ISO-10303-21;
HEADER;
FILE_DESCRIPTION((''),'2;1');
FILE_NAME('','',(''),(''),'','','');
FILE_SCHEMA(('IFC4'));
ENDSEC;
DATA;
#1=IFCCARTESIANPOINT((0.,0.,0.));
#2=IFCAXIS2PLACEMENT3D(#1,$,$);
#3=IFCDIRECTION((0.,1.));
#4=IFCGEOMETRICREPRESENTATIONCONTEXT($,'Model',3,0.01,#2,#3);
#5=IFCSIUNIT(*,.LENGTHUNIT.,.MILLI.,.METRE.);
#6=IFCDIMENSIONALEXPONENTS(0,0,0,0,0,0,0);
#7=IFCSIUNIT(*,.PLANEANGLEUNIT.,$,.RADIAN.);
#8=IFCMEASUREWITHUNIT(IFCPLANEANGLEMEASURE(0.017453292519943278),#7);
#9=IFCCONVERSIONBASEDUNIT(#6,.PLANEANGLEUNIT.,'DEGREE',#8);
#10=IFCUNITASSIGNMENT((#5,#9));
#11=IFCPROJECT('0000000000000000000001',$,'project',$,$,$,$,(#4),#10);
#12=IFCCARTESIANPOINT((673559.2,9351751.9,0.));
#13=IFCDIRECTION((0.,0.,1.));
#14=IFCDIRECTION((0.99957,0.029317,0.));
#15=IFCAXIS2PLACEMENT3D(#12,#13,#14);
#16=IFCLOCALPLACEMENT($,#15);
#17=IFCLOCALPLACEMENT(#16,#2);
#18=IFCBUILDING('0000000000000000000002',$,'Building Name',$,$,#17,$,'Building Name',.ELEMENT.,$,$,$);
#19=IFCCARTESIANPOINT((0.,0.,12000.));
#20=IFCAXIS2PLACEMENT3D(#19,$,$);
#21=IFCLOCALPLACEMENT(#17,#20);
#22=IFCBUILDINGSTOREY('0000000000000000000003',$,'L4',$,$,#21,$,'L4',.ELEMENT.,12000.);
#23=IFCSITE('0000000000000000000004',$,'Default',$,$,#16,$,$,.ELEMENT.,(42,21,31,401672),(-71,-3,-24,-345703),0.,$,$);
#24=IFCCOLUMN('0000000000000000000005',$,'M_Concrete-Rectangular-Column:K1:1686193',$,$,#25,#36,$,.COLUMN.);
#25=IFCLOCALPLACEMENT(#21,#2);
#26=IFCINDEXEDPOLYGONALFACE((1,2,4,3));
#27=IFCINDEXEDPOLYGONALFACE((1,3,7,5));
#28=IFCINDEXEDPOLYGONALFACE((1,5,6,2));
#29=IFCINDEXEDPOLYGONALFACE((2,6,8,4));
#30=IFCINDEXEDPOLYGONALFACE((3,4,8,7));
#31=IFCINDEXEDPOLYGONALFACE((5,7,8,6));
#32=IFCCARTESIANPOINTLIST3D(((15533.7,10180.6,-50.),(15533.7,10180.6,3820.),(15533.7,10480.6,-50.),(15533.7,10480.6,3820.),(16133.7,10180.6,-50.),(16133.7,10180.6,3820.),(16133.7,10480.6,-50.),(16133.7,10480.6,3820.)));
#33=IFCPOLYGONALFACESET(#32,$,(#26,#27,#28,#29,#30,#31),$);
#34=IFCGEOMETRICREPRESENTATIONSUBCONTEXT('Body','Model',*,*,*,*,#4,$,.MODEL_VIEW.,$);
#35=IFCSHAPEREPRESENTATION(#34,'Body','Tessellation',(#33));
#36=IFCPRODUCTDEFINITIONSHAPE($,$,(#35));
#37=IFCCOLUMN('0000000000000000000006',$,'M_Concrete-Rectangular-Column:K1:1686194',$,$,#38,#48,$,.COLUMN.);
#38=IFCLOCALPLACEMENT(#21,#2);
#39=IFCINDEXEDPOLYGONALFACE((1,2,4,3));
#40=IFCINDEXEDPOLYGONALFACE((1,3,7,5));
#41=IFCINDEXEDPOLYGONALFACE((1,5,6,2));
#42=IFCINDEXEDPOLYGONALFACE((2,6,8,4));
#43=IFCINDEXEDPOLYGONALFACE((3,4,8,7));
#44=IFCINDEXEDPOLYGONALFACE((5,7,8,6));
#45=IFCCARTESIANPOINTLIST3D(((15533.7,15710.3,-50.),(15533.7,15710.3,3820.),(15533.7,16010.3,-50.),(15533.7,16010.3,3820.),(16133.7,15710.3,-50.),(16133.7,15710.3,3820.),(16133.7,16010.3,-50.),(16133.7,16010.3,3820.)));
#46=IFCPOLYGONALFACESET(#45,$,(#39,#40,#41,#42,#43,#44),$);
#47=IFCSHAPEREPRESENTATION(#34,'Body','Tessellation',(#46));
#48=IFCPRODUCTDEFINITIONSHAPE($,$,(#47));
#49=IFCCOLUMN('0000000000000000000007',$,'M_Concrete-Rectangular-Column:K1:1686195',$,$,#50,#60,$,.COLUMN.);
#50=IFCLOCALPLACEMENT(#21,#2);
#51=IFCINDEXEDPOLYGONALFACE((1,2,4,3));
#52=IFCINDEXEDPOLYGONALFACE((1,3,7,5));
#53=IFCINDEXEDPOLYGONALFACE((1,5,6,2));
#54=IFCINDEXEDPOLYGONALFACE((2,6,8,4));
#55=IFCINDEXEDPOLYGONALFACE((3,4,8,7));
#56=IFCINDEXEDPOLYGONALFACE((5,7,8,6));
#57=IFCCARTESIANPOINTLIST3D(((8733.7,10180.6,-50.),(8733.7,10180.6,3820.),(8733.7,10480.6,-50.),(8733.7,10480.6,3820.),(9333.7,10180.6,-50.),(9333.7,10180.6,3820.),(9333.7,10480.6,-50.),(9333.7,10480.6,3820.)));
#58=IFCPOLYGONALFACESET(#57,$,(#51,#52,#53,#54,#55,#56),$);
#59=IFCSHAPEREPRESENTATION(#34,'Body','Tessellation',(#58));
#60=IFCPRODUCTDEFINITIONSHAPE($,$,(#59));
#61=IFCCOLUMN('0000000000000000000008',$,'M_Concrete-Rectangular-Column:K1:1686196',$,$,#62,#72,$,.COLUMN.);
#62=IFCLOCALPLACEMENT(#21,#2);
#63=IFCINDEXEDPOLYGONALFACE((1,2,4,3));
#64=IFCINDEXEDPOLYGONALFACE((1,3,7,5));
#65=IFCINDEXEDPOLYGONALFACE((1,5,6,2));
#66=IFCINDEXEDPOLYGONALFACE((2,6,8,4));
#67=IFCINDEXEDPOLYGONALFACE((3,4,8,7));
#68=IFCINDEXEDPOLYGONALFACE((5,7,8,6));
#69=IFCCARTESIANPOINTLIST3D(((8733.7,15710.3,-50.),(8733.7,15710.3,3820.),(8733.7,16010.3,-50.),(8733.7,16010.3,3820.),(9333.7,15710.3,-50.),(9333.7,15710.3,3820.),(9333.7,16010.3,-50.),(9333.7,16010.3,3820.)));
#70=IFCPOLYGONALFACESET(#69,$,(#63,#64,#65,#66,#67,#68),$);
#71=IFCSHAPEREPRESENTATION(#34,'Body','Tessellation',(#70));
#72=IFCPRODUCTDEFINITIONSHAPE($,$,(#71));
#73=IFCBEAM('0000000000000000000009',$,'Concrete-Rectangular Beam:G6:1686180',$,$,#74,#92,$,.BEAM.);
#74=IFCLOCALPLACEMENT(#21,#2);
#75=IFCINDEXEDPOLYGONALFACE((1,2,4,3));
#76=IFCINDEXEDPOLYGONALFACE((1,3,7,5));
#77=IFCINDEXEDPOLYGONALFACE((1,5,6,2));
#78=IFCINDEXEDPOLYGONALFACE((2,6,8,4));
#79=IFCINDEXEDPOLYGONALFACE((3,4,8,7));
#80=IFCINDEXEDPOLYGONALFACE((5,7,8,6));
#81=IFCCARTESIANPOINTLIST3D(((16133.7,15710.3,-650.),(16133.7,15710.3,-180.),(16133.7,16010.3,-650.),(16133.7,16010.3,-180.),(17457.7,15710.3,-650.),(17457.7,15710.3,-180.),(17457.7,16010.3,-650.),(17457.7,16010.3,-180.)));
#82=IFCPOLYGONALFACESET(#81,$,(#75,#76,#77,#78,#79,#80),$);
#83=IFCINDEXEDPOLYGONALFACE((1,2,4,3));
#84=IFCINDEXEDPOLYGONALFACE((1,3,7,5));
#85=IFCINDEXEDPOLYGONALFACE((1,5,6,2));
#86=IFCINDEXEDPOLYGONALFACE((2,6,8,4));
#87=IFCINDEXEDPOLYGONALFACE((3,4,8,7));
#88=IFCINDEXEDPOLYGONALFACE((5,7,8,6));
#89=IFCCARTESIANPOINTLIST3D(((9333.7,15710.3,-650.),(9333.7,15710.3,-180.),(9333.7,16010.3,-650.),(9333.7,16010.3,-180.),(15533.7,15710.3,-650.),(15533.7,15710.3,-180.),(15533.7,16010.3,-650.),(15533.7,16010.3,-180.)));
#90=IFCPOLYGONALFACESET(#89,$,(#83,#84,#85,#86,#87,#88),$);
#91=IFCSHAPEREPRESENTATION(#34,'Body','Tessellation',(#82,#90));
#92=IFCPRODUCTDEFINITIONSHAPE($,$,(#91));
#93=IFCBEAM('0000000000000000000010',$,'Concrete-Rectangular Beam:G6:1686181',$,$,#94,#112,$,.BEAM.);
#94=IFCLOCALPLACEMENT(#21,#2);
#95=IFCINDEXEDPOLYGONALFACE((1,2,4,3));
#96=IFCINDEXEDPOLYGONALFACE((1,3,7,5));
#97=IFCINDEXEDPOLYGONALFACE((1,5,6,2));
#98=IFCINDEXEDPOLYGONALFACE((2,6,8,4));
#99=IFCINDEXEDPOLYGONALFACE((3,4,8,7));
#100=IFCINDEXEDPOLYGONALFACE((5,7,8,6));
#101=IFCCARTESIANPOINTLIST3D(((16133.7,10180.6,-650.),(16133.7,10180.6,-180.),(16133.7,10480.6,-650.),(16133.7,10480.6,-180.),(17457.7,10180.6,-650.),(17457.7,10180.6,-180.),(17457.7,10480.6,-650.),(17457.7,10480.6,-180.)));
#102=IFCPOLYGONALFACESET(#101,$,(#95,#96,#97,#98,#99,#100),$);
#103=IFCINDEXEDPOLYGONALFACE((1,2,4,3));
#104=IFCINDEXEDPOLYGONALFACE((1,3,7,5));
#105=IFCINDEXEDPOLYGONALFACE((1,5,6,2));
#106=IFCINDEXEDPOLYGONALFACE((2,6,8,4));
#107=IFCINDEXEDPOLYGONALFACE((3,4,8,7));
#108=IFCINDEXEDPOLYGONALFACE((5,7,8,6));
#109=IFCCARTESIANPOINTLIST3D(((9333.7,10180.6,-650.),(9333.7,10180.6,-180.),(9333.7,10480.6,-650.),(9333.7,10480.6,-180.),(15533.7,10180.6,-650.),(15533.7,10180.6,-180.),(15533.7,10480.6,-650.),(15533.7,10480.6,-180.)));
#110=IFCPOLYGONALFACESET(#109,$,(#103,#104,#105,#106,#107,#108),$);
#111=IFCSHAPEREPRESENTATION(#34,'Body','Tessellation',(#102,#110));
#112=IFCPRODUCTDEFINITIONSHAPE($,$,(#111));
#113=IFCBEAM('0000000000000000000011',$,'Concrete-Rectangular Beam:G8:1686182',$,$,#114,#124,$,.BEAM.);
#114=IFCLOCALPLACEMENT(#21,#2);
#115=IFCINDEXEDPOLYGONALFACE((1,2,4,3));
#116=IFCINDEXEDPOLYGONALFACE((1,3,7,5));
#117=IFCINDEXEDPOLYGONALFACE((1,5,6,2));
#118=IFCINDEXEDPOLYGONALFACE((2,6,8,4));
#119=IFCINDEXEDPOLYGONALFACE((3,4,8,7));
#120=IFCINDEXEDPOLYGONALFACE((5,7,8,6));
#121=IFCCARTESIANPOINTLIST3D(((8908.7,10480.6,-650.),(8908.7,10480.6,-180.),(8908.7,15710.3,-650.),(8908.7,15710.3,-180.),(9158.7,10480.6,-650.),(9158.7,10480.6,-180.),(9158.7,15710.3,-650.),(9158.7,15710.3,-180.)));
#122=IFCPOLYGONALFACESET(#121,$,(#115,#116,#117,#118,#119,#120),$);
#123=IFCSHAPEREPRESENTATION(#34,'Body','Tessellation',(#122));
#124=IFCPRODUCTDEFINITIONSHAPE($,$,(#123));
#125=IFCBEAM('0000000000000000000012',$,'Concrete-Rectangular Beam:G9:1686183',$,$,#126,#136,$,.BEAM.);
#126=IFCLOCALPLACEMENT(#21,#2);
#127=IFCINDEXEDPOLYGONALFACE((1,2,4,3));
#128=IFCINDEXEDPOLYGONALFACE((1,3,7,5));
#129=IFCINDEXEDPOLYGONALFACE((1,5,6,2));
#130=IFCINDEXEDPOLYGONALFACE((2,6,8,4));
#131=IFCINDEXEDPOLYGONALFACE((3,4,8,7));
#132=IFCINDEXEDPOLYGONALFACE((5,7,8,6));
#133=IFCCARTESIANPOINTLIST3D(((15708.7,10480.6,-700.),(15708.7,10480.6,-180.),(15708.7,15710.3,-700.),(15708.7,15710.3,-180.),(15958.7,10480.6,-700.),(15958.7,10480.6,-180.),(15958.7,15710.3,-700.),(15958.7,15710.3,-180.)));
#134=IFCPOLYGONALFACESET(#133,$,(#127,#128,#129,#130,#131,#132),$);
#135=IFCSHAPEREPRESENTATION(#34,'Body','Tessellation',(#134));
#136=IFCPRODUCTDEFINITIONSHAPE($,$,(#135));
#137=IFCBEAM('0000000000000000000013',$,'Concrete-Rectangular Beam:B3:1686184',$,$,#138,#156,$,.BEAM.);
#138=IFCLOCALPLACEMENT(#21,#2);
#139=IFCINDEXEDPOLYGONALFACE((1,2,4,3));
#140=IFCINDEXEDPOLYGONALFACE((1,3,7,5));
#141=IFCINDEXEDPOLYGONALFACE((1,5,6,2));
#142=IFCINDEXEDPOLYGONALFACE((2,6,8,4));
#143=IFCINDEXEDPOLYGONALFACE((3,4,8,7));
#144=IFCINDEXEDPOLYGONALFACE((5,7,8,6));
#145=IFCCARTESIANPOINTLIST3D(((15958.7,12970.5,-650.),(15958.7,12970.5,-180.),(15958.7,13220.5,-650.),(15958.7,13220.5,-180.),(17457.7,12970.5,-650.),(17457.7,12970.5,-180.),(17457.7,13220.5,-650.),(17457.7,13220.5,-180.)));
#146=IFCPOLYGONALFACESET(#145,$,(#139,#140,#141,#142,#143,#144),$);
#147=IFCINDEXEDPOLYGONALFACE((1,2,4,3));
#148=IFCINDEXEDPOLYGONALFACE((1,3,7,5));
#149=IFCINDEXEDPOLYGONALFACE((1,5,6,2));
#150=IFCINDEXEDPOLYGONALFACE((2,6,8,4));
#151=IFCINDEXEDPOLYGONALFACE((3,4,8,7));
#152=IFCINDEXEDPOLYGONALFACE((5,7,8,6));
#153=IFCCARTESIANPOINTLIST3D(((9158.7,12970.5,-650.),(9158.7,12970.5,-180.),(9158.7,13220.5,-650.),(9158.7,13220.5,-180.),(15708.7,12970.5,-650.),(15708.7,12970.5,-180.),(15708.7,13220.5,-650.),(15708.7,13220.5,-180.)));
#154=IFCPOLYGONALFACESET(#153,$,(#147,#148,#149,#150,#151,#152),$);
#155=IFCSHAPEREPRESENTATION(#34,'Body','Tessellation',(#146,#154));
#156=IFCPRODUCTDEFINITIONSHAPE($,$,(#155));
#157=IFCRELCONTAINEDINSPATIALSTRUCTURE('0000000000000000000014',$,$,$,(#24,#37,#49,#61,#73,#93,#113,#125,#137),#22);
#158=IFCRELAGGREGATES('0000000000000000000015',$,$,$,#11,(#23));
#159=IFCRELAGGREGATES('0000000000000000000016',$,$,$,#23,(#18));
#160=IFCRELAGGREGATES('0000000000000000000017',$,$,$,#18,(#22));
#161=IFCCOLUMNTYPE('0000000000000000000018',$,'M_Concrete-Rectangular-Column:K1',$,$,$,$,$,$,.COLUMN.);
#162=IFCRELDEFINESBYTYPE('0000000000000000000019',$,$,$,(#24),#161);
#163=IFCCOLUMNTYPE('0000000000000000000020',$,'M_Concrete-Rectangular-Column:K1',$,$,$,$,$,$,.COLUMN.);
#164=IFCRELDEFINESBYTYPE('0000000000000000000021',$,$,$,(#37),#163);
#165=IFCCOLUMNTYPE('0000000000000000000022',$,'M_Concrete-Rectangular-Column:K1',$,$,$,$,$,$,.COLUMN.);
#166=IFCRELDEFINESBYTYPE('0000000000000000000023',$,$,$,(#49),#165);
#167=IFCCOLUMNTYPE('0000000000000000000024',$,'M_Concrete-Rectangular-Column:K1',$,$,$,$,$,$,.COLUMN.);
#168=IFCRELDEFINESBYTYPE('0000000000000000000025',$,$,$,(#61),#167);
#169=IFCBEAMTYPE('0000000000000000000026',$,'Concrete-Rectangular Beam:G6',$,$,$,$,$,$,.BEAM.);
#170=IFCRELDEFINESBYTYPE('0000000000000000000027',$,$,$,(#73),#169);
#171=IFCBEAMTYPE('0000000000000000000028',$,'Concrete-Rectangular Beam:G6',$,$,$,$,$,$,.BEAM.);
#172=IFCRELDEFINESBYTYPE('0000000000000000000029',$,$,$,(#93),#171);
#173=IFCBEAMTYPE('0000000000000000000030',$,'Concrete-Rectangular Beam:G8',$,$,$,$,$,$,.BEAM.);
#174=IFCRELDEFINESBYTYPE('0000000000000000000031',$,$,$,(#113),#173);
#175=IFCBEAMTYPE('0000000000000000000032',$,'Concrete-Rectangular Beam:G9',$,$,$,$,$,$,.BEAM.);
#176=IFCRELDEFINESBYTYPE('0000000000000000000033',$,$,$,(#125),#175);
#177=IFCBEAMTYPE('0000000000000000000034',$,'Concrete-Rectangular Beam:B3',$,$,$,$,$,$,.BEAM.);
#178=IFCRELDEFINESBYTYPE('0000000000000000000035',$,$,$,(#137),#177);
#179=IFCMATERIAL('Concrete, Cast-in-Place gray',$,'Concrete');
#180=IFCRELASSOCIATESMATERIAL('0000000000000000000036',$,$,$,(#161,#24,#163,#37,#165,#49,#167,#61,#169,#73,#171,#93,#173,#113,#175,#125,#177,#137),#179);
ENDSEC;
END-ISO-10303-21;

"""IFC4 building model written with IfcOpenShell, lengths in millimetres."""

from ifc_helpers import new_model, entity, si_unit, converted_unit, direction, frame, origin, place, context, subcontext, project, spatial, indexed_curve, outline, extrude, source, transform, mapped, material, type_object, type_shapes, element, save


model = new_model("IFC4")

# Units and contexts
model_context = context("Model", 3, precision=0.01, world=origin(), true_north=direction((0.0, 1.0)))
body_context = subcontext(model_context, "Body", "Model", "MODEL_VIEW")
ifc_project = project(units=[si_unit("LENGTHUNIT", "METRE", prefix="MILLI"), converted_unit("PLANEANGLEUNIT", "DEGREE", entity("IfcPlaneAngleMeasure", 0.017453292519943278), si_unit("PLANEANGLEUNIT", "RADIAN"), dimensions=[0, 0, 0, 0, 0, 0, 0])], contexts=[model_context])

# Site, building, storey
site_placement = place(None, frame((673559.2, 9351751.9, 0.0), z_axis=(0.0, 0.0, 1.0), x_axis=(0.99957, 0.029317, 0.0)))
site = spatial("IfcSite", under=ifc_project, at=site_placement, Name="Default", CompositionType="ELEMENT", RefLatitude=(42, 21, 31, 401672), RefLongitude=(-71, -3, -24, -345703), RefElevation=0.0)
building_placement = place(site_placement, origin())
building = spatial("IfcBuilding", under=site, at=building_placement, Name="Building Name", LongName="Building Name", CompositionType="ELEMENT")
storey_placement = place(building_placement, frame((0.0, 0.0, 12000.0)))
storey = spatial("IfcBuildingStorey", under=building, at=storey_placement, Name="L4", LongName="L4", CompositionType="ELEMENT", Elevation=12000.0)

# Columns
ifc_material = material(Name="Concrete, Cast-in-Place gray", Category="Concrete")
column_type_1 = type_object("IfcColumnType", Name="M_Concrete-Rectangular-Column:K1", PredefinedType="COLUMN", material=ifc_material)
shared_shape_1 = source(origin(), body_context, "Body", "SweptSolid", [
    extrude(outline(indexed_curve([(-150.0, -300.0), (150.0, -300.0), (150.0, 300.0), (-150.0, 300.0), (-150.0, -300.0)], self_intersect=False)), frame((15833.7, 10330.6, 11950.0), z_axis=(0.0, 0.0, 1.0), x_axis=(0.0, -1.0, 0.0)), (0.0, 0.0, 1.0), 3870.0),
])
type_shapes(column_type_1, [shared_shape_1])
column_1_placement = place(storey_placement, frame((0.0, 0.0, -12000.0)))
element("IfcColumn", 1, at=column_1_placement, inside=storey, type_object=column_type_1, material=ifc_material, Name="M_Concrete-Rectangular-Column:K1:1686193", PredefinedType="COLUMN", context=body_context, shape_type="MappedRepresentation", body=[
    mapped(shared_shape_1, transform((0.0, 0.0, 0.0), scale=1.0)),
])
column_type_2 = type_object("IfcColumnType", Name="M_Concrete-Rectangular-Column:K1", PredefinedType="COLUMN", material=ifc_material)
shared_shape_2 = source(origin(), body_context, "Body", "SweptSolid", [
    extrude(outline(indexed_curve([(-150.0, -300.0), (150.0, -300.0), (150.0, 300.0), (-150.0, 300.0), (-150.0, -300.0)], self_intersect=False)), frame((15833.7, 15860.3, 11950.0), z_axis=(0.0, 0.0, 1.0), x_axis=(0.0, -1.0, 0.0)), (0.0, 0.0, 1.0), 3870.0),
])
type_shapes(column_type_2, [shared_shape_2])
column_2_placement = place(storey_placement, frame((0.0, 0.0, -12000.0)))
element("IfcColumn", 2, at=column_2_placement, inside=storey, type_object=column_type_2, material=ifc_material, Name="M_Concrete-Rectangular-Column:K1:1686194", PredefinedType="COLUMN", context=body_context, shape_type="MappedRepresentation", body=[
    mapped(shared_shape_2, transform((0.0, 0.0, 0.0), scale=1.0)),
])
column_type_3 = type_object("IfcColumnType", Name="M_Concrete-Rectangular-Column:K1", PredefinedType="COLUMN", material=ifc_material)
shared_shape_3 = source(origin(), body_context, "Body", "SweptSolid", [
    extrude(outline(indexed_curve([(-150.0, -300.0), (150.0, -300.0), (150.0, 300.0), (-150.0, 300.0), (-150.0, -300.0)], self_intersect=False)), frame((9033.7, 10330.6, 11950.0), z_axis=(0.0, 0.0, 1.0), x_axis=(0.0, -1.0, 0.0)), (0.0, 0.0, 1.0), 3870.0),
])
type_shapes(column_type_3, [shared_shape_3])
column_3_placement = place(storey_placement, frame((0.0, 0.0, -12000.0)))
element("IfcColumn", 3, at=column_3_placement, inside=storey, type_object=column_type_3, material=ifc_material, Name="M_Concrete-Rectangular-Column:K1:1686195", PredefinedType="COLUMN", context=body_context, shape_type="MappedRepresentation", body=[
    mapped(shared_shape_3, transform((0.0, 0.0, 0.0), scale=1.0)),
])
column_type_4 = type_object("IfcColumnType", Name="M_Concrete-Rectangular-Column:K1", PredefinedType="COLUMN", material=ifc_material)
shared_shape_4 = source(origin(), body_context, "Body", "SweptSolid", [
    extrude(outline(indexed_curve([(-150.0, -300.0), (150.0, -300.0), (150.0, 300.0), (-150.0, 300.0), (-150.0, -300.0)], self_intersect=False)), frame((9033.7, 15860.3, 11950.0), z_axis=(0.0, 0.0, 1.0), x_axis=(0.0, -1.0, 0.0)), (0.0, 0.0, 1.0), 3870.0),
])
type_shapes(column_type_4, [shared_shape_4])
column_4_placement = place(storey_placement, frame((0.0, 0.0, -12000.0)))
element("IfcColumn", 4, at=column_4_placement, inside=storey, type_object=column_type_4, material=ifc_material, Name="M_Concrete-Rectangular-Column:K1:1686196", PredefinedType="COLUMN", context=body_context, shape_type="MappedRepresentation", body=[
    mapped(shared_shape_4, transform((0.0, 0.0, 0.0), scale=1.0)),
])

# Beams
beam_type_1 = type_object("IfcBeamType", Name="Concrete-Rectangular Beam:G6", PredefinedType="BEAM", material=ifc_material)
shared_shape_5 = source(origin(), body_context, "Body", "SweptSolid", [
    extrude(outline(indexed_curve([(-235.0, -150.0), (235.0, -150.0), (235.0, 150.0), (-235.0, 150.0), (-235.0, -150.0)], self_intersect=False)), frame((16133.7, 15860.3, 11585.0), z_axis=(1.0, 0.0, 0.0), x_axis=(0.0, 0.0, -1.0)), (0.0, 0.0, 1.0), 1324.0),
    extrude(outline(indexed_curve([(-235.0, -150.0), (235.0, -150.0), (235.0, 150.0), (-235.0, 150.0), (-235.0, -150.0)], self_intersect=False)), frame((9333.7, 15860.3, 11585.0), z_axis=(1.0, 0.0, 0.0), x_axis=(0.0, 0.0, -1.0)), (0.0, 0.0, 1.0), 6200.0),
])
type_shapes(beam_type_1, [shared_shape_5])
beam_1_placement = place(storey_placement, frame((0.0, 0.0, -12000.0)))
element("IfcBeam", 5, at=beam_1_placement, inside=storey, type_object=beam_type_1, material=ifc_material, Name="Concrete-Rectangular Beam:G6:1686180", PredefinedType="BEAM", context=body_context, shape_type="MappedRepresentation", body=[
    mapped(shared_shape_5, transform((0.0, 0.0, 0.0), scale=1.0)),
])
beam_type_2 = type_object("IfcBeamType", Name="Concrete-Rectangular Beam:G6", PredefinedType="BEAM", material=ifc_material)
shared_shape_6 = source(origin(), body_context, "Body", "SweptSolid", [
    extrude(outline(indexed_curve([(-235.0, -150.0), (235.0, -150.0), (235.0, 150.0), (-235.0, 150.0), (-235.0, -150.0)], self_intersect=False)), frame((16133.7, 10330.6, 11585.0), z_axis=(1.0, 0.0, 0.0), x_axis=(0.0, 0.0, -1.0)), (0.0, 0.0, 1.0), 1324.0),
    extrude(outline(indexed_curve([(-235.0, -150.0), (235.0, -150.0), (235.0, 150.0), (-235.0, 150.0), (-235.0, -150.0)], self_intersect=False)), frame((9333.7, 10330.6, 11585.0), z_axis=(1.0, 0.0, 0.0), x_axis=(0.0, 0.0, -1.0)), (0.0, 0.0, 1.0), 6200.0),
])
type_shapes(beam_type_2, [shared_shape_6])
beam_2_placement = place(storey_placement, frame((0.0, 0.0, -12000.0)))
element("IfcBeam", 6, at=beam_2_placement, inside=storey, type_object=beam_type_2, material=ifc_material, Name="Concrete-Rectangular Beam:G6:1686181", PredefinedType="BEAM", context=body_context, shape_type="MappedRepresentation", body=[
    mapped(shared_shape_6, transform((0.0, 0.0, 0.0), scale=1.0)),
])
beam_type_3 = type_object("IfcBeamType", Name="Concrete-Rectangular Beam:G8", PredefinedType="BEAM", material=ifc_material)
shared_shape_7 = source(origin(), body_context, "Body", "SweptSolid", [
    extrude(outline(indexed_curve([(-125.0, -235.0), (125.0, -235.0), (125.0, 235.0), (-125.0, 235.0), (-125.0, -235.0)], self_intersect=False)), frame((9033.7, 15710.3, 11585.0), z_axis=(0.0, -1.0, 0.0), x_axis=(-1.0, 0.0, 0.0)), (0.0, 0.0, 1.0), 5229.7),
])
type_shapes(beam_type_3, [shared_shape_7])
beam_3_placement = place(storey_placement, frame((0.0, 0.0, -12000.0)))
element("IfcBeam", 7, at=beam_3_placement, inside=storey, type_object=beam_type_3, material=ifc_material, Name="Concrete-Rectangular Beam:G8:1686182", PredefinedType="BEAM", context=body_context, shape_type="MappedRepresentation", body=[
    mapped(shared_shape_7, transform((0.0, 0.0, 0.0), scale=1.0)),
])
beam_type_4 = type_object("IfcBeamType", Name="Concrete-Rectangular Beam:G9", PredefinedType="BEAM", material=ifc_material)
shared_shape_8 = source(origin(), body_context, "Body", "SweptSolid", [
    extrude(outline(indexed_curve([(-125.0, -260.0), (125.0, -260.0), (125.0, 260.0), (-125.0, 260.0), (-125.0, -260.0)], self_intersect=False)), frame((15833.7, 15710.3, 11560.0), z_axis=(0.0, -1.0, 0.0), x_axis=(-1.0, 0.0, 0.0)), (0.0, 0.0, 1.0), 5229.7),
])
type_shapes(beam_type_4, [shared_shape_8])
beam_4_placement = place(storey_placement, frame((0.0, 0.0, -12000.0)))
element("IfcBeam", 8, at=beam_4_placement, inside=storey, type_object=beam_type_4, material=ifc_material, Name="Concrete-Rectangular Beam:G9:1686183", PredefinedType="BEAM", context=body_context, shape_type="MappedRepresentation", body=[
    mapped(shared_shape_8, transform((0.0, 0.0, 0.0), scale=1.0)),
])
beam_type_5 = type_object("IfcBeamType", Name="Concrete-Rectangular Beam:B3", PredefinedType="BEAM", material=ifc_material)
shared_shape_9 = source(origin(), body_context, "Body", "SweptSolid", [
    extrude(outline(indexed_curve([(-235.0, -125.0), (235.0, -125.0), (235.0, 125.0), (-235.0, 125.0), (-235.0, -125.0)], self_intersect=False)), frame((15958.7, 13095.5, 11585.0), z_axis=(1.0, 0.0, 0.0), x_axis=(0.0, 0.0, -1.0)), (0.0, 0.0, 1.0), 1499.0),
    extrude(outline(indexed_curve([(-235.0, -125.0), (235.0, -125.0), (235.0, 125.0), (-235.0, 125.0), (-235.0, -125.0)], self_intersect=False)), frame((9158.7, 13095.5, 11585.0), z_axis=(1.0, 0.0, 0.0), x_axis=(0.0, 0.0, -1.0)), (0.0, 0.0, 1.0), 6550.0),
])
type_shapes(beam_type_5, [shared_shape_9])
beam_5_placement = place(storey_placement, frame((0.0, 0.0, -12000.0)))
element("IfcBeam", 9, at=beam_5_placement, inside=storey, type_object=beam_type_5, material=ifc_material, Name="Concrete-Rectangular Beam:B3:1686184", PredefinedType="BEAM", context=body_context, shape_type="MappedRepresentation", body=[
    mapped(shared_shape_9, transform((0.0, 0.0, 0.0), scale=1.0)),
])

save(model, "model.ifc")
